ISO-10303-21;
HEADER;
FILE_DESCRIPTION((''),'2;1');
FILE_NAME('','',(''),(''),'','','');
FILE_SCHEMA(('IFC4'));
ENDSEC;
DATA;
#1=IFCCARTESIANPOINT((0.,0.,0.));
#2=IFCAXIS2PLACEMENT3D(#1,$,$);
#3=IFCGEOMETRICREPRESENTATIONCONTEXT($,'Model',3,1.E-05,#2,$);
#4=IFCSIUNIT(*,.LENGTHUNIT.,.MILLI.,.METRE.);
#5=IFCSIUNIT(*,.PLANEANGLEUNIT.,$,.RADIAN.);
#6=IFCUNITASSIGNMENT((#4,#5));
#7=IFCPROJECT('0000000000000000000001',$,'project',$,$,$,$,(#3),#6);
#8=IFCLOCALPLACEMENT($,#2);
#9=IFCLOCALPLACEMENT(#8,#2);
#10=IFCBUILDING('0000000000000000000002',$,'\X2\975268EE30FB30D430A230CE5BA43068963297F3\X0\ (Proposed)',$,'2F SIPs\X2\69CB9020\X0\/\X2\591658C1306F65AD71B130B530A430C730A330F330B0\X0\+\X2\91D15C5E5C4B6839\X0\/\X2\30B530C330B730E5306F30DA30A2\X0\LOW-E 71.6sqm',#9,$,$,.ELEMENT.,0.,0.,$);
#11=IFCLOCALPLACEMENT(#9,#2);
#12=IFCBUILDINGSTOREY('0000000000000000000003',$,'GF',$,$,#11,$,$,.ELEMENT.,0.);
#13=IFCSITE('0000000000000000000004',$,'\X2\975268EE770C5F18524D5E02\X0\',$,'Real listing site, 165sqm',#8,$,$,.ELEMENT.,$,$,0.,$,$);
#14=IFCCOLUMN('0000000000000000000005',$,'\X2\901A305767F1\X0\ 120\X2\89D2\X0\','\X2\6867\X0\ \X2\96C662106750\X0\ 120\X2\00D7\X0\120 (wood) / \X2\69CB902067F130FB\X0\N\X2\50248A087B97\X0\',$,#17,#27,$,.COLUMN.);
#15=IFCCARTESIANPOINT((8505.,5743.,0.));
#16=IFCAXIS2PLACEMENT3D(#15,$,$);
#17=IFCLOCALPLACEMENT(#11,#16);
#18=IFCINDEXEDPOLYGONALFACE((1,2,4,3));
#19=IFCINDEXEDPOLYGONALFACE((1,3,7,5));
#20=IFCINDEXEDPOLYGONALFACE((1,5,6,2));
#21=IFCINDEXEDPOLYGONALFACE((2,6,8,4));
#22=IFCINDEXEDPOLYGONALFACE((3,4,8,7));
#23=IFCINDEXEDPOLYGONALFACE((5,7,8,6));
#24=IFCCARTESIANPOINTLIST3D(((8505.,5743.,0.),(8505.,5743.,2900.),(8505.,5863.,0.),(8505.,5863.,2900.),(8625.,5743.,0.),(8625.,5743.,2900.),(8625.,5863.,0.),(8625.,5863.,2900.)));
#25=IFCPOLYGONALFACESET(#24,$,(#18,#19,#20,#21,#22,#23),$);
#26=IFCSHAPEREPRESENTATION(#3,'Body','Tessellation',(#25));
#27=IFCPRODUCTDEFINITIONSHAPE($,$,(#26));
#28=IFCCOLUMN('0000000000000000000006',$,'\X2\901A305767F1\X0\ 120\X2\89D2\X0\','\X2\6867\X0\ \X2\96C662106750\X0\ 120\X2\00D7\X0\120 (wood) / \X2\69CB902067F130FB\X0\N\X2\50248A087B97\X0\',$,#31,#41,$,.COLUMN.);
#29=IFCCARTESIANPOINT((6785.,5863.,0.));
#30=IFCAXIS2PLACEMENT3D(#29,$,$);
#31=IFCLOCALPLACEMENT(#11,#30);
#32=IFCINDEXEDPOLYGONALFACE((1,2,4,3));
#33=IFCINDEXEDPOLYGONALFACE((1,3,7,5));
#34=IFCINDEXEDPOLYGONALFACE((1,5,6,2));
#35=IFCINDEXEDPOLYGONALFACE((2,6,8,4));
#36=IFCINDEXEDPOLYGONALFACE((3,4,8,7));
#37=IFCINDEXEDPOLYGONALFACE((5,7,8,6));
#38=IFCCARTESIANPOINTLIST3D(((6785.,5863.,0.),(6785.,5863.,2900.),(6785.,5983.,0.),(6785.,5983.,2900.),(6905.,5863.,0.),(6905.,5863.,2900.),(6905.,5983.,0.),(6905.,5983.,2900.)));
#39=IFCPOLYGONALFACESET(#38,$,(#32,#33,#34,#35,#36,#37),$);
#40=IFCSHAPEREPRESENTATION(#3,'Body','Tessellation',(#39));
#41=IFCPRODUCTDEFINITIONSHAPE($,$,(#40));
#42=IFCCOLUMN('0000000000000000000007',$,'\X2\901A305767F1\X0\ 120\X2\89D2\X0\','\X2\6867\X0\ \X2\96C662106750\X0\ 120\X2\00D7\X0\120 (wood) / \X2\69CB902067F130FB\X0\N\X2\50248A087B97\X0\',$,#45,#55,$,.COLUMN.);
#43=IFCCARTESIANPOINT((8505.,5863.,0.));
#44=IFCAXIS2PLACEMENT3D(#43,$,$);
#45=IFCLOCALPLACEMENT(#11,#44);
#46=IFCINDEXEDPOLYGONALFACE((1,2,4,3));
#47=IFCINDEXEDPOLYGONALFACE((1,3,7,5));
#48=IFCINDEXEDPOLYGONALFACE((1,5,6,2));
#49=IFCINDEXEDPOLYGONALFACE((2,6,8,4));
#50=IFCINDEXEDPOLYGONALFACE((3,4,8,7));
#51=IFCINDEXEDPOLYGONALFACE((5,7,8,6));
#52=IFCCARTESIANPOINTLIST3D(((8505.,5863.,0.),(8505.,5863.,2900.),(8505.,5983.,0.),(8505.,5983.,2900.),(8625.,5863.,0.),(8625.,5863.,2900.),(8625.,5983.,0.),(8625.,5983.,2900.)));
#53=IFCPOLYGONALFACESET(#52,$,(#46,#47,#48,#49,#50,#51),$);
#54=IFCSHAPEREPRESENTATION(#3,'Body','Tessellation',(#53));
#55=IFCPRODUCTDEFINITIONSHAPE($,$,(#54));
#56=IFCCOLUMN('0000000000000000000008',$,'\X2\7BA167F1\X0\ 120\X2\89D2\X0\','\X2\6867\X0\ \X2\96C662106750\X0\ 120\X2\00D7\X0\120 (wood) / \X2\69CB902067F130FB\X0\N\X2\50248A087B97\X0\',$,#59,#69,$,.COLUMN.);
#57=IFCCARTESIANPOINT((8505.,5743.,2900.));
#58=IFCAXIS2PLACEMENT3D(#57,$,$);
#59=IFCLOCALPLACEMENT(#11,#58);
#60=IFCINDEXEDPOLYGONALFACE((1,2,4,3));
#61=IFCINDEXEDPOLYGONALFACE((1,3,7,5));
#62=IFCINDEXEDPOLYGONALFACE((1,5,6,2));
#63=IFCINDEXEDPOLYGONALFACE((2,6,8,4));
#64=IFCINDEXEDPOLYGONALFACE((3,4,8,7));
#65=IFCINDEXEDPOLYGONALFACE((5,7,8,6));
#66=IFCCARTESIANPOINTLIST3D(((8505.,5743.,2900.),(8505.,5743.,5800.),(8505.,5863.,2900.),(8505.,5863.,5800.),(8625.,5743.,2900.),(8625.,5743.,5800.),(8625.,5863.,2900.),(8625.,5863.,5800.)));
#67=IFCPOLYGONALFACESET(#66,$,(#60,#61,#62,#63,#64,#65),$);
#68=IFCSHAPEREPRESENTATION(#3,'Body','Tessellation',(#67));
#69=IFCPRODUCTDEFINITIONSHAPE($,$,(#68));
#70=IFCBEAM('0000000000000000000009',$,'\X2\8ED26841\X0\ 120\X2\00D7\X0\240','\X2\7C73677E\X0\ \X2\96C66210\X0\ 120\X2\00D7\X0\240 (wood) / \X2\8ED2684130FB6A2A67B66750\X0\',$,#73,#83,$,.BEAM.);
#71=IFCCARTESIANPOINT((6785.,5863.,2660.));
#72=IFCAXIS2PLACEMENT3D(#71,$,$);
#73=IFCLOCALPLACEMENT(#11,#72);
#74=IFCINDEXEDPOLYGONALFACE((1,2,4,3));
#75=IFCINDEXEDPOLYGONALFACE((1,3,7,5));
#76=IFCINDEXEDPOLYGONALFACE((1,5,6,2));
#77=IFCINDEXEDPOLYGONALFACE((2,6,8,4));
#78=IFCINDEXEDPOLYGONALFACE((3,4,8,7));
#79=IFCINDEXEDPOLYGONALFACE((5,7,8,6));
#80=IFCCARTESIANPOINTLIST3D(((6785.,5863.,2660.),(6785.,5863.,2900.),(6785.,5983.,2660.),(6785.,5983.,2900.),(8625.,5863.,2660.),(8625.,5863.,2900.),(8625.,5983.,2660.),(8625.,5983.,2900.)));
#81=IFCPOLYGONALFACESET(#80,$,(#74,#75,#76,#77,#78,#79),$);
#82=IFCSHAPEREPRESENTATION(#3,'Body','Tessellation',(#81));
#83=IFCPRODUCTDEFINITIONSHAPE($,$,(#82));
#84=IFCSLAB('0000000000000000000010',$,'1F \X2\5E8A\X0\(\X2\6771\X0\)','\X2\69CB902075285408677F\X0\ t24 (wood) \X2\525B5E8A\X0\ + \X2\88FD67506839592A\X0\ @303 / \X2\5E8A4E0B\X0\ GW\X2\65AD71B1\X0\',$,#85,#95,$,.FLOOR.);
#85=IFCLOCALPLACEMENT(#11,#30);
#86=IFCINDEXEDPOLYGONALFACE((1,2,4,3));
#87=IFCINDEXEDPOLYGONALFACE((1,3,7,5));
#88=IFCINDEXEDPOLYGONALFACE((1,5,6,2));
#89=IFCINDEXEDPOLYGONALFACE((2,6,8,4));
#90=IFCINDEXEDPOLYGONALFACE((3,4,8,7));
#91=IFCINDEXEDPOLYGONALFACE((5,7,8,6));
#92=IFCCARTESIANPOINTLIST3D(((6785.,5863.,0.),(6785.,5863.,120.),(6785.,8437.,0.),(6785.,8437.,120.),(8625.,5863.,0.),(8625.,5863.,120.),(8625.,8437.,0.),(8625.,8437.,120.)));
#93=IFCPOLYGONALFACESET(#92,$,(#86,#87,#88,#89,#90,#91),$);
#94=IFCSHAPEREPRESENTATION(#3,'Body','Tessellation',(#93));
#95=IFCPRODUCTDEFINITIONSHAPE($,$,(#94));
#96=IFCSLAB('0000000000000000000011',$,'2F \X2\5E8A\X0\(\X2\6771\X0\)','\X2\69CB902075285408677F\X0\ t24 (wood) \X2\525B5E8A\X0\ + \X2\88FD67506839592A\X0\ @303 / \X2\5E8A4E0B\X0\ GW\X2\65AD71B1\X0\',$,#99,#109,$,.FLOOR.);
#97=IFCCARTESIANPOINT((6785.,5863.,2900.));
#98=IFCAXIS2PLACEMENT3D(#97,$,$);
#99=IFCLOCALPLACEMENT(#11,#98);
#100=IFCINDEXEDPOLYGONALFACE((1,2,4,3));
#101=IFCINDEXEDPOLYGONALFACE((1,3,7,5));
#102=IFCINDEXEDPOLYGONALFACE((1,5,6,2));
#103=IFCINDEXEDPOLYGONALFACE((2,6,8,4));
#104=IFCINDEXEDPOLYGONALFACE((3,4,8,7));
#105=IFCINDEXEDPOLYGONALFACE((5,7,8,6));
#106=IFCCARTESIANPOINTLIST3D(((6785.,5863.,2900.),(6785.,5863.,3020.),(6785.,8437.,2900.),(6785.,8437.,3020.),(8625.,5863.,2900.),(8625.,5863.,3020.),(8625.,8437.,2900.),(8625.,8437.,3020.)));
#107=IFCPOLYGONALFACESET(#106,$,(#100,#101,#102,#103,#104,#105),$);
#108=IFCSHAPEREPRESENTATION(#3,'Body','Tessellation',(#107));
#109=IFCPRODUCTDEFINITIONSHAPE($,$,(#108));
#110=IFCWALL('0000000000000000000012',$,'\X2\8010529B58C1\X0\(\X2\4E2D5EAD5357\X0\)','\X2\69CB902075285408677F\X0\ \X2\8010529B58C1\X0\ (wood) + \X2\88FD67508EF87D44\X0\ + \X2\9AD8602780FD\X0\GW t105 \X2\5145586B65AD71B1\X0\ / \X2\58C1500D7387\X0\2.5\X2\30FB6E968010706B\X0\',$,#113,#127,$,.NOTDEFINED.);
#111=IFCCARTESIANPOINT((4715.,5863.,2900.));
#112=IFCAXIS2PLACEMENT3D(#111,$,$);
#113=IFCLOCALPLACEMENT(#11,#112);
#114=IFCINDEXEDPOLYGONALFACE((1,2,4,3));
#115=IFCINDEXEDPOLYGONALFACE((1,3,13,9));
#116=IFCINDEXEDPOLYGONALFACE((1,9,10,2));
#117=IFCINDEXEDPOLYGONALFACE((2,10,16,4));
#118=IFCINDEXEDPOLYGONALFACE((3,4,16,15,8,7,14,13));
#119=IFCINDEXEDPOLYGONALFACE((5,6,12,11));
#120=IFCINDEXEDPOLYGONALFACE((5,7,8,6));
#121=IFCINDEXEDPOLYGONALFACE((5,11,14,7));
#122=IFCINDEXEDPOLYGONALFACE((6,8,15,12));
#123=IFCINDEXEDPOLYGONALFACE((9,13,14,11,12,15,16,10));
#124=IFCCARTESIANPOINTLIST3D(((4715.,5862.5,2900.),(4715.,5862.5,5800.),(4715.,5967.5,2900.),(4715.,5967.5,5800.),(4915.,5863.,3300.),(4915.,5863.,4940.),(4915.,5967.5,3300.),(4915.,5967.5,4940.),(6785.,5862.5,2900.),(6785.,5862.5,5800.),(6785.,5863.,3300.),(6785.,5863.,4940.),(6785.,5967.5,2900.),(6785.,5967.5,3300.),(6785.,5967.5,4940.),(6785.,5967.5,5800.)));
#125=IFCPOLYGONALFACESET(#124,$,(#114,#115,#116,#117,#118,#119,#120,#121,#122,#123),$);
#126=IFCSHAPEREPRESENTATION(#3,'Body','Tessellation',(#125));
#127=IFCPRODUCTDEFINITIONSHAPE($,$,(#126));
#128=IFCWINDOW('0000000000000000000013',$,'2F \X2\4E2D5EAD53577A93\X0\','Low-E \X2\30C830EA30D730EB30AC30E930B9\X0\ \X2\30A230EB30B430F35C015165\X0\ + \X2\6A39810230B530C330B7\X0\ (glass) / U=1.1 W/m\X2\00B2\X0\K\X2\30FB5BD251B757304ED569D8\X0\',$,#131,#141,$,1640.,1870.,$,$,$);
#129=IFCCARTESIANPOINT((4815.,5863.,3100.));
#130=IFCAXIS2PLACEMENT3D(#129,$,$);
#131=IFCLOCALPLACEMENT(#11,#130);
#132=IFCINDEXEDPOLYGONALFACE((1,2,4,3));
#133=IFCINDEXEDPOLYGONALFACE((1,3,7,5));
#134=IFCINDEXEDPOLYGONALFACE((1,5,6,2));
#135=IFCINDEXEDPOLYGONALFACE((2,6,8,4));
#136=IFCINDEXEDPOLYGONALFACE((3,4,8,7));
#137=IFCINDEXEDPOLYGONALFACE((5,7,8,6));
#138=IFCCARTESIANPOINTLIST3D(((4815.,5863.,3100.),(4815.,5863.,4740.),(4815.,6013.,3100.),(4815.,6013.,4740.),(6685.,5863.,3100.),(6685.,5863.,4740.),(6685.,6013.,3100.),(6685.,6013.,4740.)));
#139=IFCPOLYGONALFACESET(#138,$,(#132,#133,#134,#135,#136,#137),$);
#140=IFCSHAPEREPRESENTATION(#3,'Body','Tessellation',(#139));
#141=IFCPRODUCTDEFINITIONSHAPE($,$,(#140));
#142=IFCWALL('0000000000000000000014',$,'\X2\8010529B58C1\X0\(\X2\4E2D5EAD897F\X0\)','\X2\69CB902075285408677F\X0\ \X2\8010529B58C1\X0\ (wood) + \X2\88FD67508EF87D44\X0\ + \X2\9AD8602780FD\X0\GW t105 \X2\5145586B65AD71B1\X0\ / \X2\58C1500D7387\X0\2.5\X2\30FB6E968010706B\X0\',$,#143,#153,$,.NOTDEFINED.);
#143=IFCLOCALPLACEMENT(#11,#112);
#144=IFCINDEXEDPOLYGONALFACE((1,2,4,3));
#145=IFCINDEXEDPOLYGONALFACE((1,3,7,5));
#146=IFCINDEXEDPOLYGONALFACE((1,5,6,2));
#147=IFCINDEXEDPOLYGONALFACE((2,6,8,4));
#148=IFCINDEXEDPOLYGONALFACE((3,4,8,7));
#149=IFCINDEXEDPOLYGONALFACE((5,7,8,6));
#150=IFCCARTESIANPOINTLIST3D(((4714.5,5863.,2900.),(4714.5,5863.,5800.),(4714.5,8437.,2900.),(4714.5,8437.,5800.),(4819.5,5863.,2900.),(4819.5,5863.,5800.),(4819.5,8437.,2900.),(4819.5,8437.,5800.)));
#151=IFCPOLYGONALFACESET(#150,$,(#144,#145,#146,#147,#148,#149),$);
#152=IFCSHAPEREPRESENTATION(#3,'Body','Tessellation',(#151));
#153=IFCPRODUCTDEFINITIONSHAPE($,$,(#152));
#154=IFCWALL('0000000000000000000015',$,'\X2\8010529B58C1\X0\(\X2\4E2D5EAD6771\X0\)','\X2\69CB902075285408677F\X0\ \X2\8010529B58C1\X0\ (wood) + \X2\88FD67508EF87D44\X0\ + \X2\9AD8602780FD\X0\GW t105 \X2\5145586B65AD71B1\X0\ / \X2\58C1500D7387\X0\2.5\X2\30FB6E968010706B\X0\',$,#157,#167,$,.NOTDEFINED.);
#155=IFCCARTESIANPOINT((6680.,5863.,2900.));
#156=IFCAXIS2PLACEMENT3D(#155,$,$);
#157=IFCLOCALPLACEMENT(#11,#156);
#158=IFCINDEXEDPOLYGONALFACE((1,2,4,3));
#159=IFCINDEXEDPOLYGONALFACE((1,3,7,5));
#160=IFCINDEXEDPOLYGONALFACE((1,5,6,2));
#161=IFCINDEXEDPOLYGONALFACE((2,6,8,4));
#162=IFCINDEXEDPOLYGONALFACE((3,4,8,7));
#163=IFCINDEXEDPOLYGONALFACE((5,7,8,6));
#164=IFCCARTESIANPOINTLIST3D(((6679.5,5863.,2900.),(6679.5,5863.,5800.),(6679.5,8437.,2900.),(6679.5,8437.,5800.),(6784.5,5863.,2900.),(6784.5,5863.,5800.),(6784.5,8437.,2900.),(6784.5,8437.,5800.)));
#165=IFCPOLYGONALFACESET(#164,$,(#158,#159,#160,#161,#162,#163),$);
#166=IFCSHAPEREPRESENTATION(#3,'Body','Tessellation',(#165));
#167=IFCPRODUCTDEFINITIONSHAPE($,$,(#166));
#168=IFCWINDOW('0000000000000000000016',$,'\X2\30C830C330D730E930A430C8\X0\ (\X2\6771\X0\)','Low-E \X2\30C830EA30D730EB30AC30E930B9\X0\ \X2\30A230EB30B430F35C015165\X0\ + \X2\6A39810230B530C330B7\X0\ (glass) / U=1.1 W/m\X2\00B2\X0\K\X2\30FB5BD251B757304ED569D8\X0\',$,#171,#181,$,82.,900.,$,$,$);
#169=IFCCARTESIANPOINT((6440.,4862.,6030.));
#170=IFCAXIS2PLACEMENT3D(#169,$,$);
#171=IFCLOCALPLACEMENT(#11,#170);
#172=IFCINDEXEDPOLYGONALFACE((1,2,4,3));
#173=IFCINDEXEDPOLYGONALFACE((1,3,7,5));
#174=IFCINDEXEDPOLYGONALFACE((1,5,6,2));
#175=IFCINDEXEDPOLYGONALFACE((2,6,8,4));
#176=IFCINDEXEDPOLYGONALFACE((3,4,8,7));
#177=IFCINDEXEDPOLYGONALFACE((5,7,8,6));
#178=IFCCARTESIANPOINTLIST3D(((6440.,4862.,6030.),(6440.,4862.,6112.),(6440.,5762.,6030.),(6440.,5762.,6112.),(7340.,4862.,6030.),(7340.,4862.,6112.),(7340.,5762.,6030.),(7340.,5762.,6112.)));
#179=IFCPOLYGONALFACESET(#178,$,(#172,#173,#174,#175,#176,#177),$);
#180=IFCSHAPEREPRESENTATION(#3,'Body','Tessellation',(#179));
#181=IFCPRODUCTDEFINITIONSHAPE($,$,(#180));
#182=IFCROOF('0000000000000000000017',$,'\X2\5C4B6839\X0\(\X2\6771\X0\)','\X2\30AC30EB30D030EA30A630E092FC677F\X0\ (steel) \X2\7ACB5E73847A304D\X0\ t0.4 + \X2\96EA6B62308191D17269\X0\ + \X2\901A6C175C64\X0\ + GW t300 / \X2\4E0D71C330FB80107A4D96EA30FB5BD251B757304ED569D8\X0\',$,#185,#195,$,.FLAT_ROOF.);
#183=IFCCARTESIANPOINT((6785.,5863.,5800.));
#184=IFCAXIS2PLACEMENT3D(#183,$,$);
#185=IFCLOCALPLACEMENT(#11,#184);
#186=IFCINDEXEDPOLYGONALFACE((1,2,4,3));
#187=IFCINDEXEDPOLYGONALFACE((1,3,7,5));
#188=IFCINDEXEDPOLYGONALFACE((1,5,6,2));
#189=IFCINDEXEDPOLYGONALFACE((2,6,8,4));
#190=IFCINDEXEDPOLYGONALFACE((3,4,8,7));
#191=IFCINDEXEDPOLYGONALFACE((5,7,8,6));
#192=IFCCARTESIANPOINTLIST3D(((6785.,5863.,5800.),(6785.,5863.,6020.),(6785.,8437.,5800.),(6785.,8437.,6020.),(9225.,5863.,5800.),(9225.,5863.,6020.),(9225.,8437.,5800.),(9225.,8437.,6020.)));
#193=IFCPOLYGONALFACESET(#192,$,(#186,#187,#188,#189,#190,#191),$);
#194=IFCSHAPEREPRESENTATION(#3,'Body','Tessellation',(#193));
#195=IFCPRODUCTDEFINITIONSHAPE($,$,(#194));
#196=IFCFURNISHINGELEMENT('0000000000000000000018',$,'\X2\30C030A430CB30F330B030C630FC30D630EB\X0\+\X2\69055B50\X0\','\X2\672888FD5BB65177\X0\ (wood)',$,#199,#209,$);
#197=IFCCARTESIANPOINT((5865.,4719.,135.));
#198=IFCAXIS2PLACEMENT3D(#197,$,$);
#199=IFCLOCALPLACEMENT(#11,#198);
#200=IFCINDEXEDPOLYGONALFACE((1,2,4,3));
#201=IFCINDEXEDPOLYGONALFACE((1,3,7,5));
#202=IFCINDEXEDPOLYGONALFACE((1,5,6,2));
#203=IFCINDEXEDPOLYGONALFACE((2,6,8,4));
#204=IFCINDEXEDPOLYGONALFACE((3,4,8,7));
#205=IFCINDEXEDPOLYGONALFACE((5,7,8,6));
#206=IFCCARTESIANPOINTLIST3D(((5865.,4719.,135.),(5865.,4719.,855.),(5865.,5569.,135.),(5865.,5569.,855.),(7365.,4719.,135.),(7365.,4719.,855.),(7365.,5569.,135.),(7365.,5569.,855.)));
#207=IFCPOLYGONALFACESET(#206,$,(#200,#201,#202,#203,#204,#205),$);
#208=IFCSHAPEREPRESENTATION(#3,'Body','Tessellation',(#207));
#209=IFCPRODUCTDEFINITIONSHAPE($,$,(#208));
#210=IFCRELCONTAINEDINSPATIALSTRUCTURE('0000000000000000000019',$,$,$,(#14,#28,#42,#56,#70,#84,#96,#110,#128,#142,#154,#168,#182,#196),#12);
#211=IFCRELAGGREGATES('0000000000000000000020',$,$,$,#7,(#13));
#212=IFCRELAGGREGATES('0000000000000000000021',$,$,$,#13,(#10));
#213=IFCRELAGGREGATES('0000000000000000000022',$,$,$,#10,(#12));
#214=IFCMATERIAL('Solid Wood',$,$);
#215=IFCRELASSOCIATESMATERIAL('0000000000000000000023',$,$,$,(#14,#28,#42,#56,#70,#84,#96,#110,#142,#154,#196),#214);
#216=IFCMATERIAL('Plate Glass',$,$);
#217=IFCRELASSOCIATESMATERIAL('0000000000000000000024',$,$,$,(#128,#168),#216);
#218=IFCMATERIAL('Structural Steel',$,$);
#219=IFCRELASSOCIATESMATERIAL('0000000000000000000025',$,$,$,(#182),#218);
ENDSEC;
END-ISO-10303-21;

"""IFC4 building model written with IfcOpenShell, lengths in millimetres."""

from ifc_helpers import new_model, si_unit, frame, frame_2d, origin, place, context, project, spatial, rectangle, extrude, material, element, fill, save


model = new_model("IFC4")

# Units and contexts
model_context = context("Model", 3, precision=1e-05, world=origin())
ifc_project = project(units=[si_unit("LENGTHUNIT", "METRE", prefix="MILLI"), si_unit("PLANEANGLEUNIT", "RADIAN")], contexts=[model_context])

# Site, building, storey
site_placement = place(None, origin())
site = spatial("IfcSite", under=ifc_project, at=site_placement, Name="青森県弘前市", ObjectType="Real listing site, 165sqm", CompositionType="ELEMENT", RefElevation=0.0)
building_placement = place(site_placement, origin())
building = spatial("IfcBuilding", under=site, at=building_placement, Name="青森・ピアノ室と防音 (Proposed)", ObjectType="2F SIPs構造/外壁は断熱サイディング+金属屋根/サッシュはペアLOW-E 71.6sqm", CompositionType="ELEMENT", ElevationOfRefHeight=0.0, ElevationOfTerrain=0.0)
storey_placement = place(building_placement, origin())
storey = spatial("IfcBuildingStorey", under=building, at=storey_placement, Name="GF", CompositionType="ELEMENT", Elevation=0.0)

# Columns
ifc_material_1 = material(Name="Solid Wood")
column_1_placement = place(storey_placement, frame((8505.0, 5743.0, 0.0)))
element("IfcColumn", 1, at=column_1_placement, inside=storey, material=ifc_material_1, Name="通し柱 120角", Description="桧 集成材 120×120 (wood) / 構造柱・N値計算", PredefinedType="COLUMN", context=model_context, shape_type="SweptSolid", body=[
    extrude(rectangle(XDim=120.0, YDim=120.0, at=frame_2d((60.0, 60.0))), frame((8505.0, 5743.0, 0.0)), (0.0, 0.0, 1.0), 2900.0),
])
column_2_placement = place(storey_placement, frame((6785.0, 5863.0, 0.0)))
element("IfcColumn", 2, at=column_2_placement, inside=storey, material=ifc_material_1, Name="通し柱 120角", Description="桧 集成材 120×120 (wood) / 構造柱・N値計算", PredefinedType="COLUMN", context=model_context, shape_type="SweptSolid", body=[
    extrude(rectangle(XDim=120.0, YDim=120.0, at=frame_2d((60.0, 60.0))), frame((6785.0, 5863.0, 0.0)), (0.0, 0.0, 1.0), 2900.0),
])
column_3_placement = place(storey_placement, frame((8505.0, 5863.0, 0.0)))
element("IfcColumn", 3, at=column_3_placement, inside=storey, material=ifc_material_1, Name="通し柱 120角", Description="桧 集成材 120×120 (wood) / 構造柱・N値計算", PredefinedType="COLUMN", context=model_context, shape_type="SweptSolid", body=[
    extrude(rectangle(XDim=120.0, YDim=120.0, at=frame_2d((60.0, 60.0))), frame((8505.0, 5863.0, 0.0)), (0.0, 0.0, 1.0), 2900.0),
])
column_4_placement = place(storey_placement, frame((8505.0, 5743.0, 2900.0)))
element("IfcColumn", 4, at=column_4_placement, inside=storey, material=ifc_material_1, Name="管柱 120角", Description="桧 集成材 120×120 (wood) / 構造柱・N値計算", PredefinedType="COLUMN", context=model_context, shape_type="SweptSolid", body=[
    extrude(rectangle(XDim=120.0, YDim=120.0, at=frame_2d((60.0, 60.0))), frame((8505.0, 5743.0, 2900.0)), (0.0, 0.0, 1.0), 2900.0),
])

# Beam
beam_1_placement = place(storey_placement, frame((6785.0, 5863.0, 2660.0)))
element("IfcBeam", 5, at=beam_1_placement, inside=storey, material=ifc_material_1, Name="軒桁 120×240", Description="米松 集成 120×240 (wood) / 軒桁・横架材", PredefinedType="BEAM", context=model_context, shape_type="SweptSolid", body=[
    extrude(rectangle(XDim=1840.0, YDim=120.0, at=frame_2d((920.0, 60.0))), frame((6785.0, 5863.0, 2660.0)), (0.0, 0.0, 1.0), 240.0),
])

# Slabs
slab_1_placement = place(storey_placement, frame((6785.0, 5863.0, 0.0)))
element("IfcSlab", 6, at=slab_1_placement, inside=storey, material=ifc_material_1, Name="1F 床(東)", Description="構造用合板 t24 (wood) 剛床 + 製材根太 @303 / 床下 GW断熱", PredefinedType="FLOOR", context=model_context, shape_type="SweptSolid", body=[
    extrude(rectangle(XDim=1840.0, YDim=2574.0, at=frame_2d((920.0, 1287.0))), frame((6785.0, 5863.0, 0.0)), (0.0, 0.0, 1.0), 120.0),
])
slab_2_placement = place(storey_placement, frame((6785.0, 5863.0, 2900.0)))
element("IfcSlab", 7, at=slab_2_placement, inside=storey, material=ifc_material_1, Name="2F 床(東)", Description="構造用合板 t24 (wood) 剛床 + 製材根太 @303 / 床下 GW断熱", PredefinedType="FLOOR", context=model_context, shape_type="SweptSolid", body=[
    extrude(rectangle(XDim=1840.0, YDim=2574.0, at=frame_2d((920.0, 1287.0))), frame((6785.0, 5863.0, 2900.0)), (0.0, 0.0, 1.0), 120.0),
])

# Wall, opening, window
wall_1_placement = place(storey_placement, frame((4715.0, 5863.0, 2900.0)))
wall_1 = element("IfcWall", 8, at=wall_1_placement, inside=storey, material=ifc_material_1, Name="耐力壁(中庭南)", Description="構造用合板 耐力壁 (wood) + 製材軸組 + 高性能GW t105 充填断熱 / 壁倍率2.5・準耐火", PredefinedType="NOTDEFINED", context=model_context, shape_type="SweptSolid", body=[
    extrude(rectangle(XDim=2070.0, YDim=105.0, at=frame_2d((1035.0, 52.0))), frame((4715.0, 5863.0, 2900.0)), (0.0, 0.0, 1.0), 2900.0),
])
opening_placement = place(storey_placement, frame((4815.0, 5863.0, 3100.0)))
opening = element("IfcOpeningElement", 9, at=opening_placement, cuts=wall_1, PredefinedType="NOTDEFINED", context=model_context, shape_type="SweptSolid", body=[
    extrude(rectangle(XDim=1870.0, YDim=150.0, at=frame_2d((935.0, 75.0))), frame((4815.0, 5863.0, 3100.0)), (0.0, 0.0, 1.0), 1640.0),
])
ifc_material_2 = material(Name="Plate Glass")
window_1_placement = place(storey_placement, frame((4815.0, 5863.0, 3100.0)))
window_1 = element("IfcWindow", 10, at=window_1_placement, inside=storey, material=ifc_material_2, Name="2F 中庭南窓", Description="Low-E トリプルガラス アルゴン封入 + 樹脂サッシ (glass) / U=1.1 W/m²K・寒冷地仕様", OverallHeight=1640.0, OverallWidth=1870.0, context=model_context, shape_type="SweptSolid", body=[
    extrude(rectangle(XDim=1870.0, YDim=150.0, at=frame_2d((935.0, 75.0))), frame((4815.0, 5863.0, 3100.0)), (0.0, 0.0, 1.0), 1640.0),
])
fill(opening, window_1)

# Walls
wall_2_placement = place(storey_placement, frame((4715.0, 5863.0, 2900.0)))
element("IfcWall", 11, at=wall_2_placement, inside=storey, material=ifc_material_1, Name="耐力壁(中庭西)", Description="構造用合板 耐力壁 (wood) + 製材軸組 + 高性能GW t105 充填断熱 / 壁倍率2.5・準耐火", PredefinedType="NOTDEFINED", context=model_context, shape_type="SweptSolid", body=[
    extrude(rectangle(XDim=105.0, YDim=2574.0, at=frame_2d((52.0, 1287.0))), frame((4715.0, 5863.0, 2900.0)), (0.0, 0.0, 1.0), 2900.0),
])
wall_3_placement = place(storey_placement, frame((6680.0, 5863.0, 2900.0)))
element("IfcWall", 12, at=wall_3_placement, inside=storey, material=ifc_material_1, Name="耐力壁(中庭東)", Description="構造用合板 耐力壁 (wood) + 製材軸組 + 高性能GW t105 充填断熱 / 壁倍率2.5・準耐火", PredefinedType="NOTDEFINED", context=model_context, shape_type="SweptSolid", body=[
    extrude(rectangle(XDim=105.0, YDim=2574.0, at=frame_2d((52.0, 1287.0))), frame((6680.0, 5863.0, 2900.0)), (0.0, 0.0, 1.0), 2900.0),
])

# Window
window_2_placement = place(storey_placement, frame((6440.0, 4862.0, 6030.0)))
element("IfcWindow", 13, at=window_2_placement, inside=storey, material=ifc_material_2, Name="トップライト (東)", Description="Low-E トリプルガラス アルゴン封入 + 樹脂サッシ (glass) / U=1.1 W/m²K・寒冷地仕様", OverallHeight=82.0, OverallWidth=900.0, context=model_context, shape_type="SweptSolid", body=[
    extrude(rectangle(XDim=900.0, YDim=900.0, at=frame_2d((450.0, 450.0))), frame((6440.0, 4862.0, 6030.0)), (0.0, 0.0, 1.0), 82.0),
])

# Roof
ifc_material_3 = material(Name="Structural Steel")
for number, where, name in (
    (14, (6785.0, 5863.0, 5800.0), "屋根(東)"),
):
    element("IfcRoof", number, at=place(storey_placement, frame(where)), inside=storey, material=ifc_material_3, Name=name, Description="ガルバリウム鋼板 (steel) 立平葺き t0.4 + 雪止め金物 + 通気層 + GW t300 / 不燃・耐積雪・寒冷地仕様", PredefinedType="FLAT_ROOF", context=model_context, shape_type="SweptSolid", body=[
        extrude(rectangle(XDim=2440.0, YDim=2574.0, at=frame_2d((1220.0, 1287.0))), frame((6785.0, 5863.0, 5800.0)), (0.0, 0.0, 1.0), 220.0),
    ])

# Furnishing element
furnishing_1_placement = place(storey_placement, frame((5865.0, 4719.0, 135.0)))
element("IfcFurnishingElement", 15, at=furnishing_1_placement, inside=storey, material=ifc_material_1, Name="ダイニングテーブル+椅子", Description="木製家具 (wood)", context=model_context, shape_type="SweptSolid", body=[
    extrude(rectangle(XDim=1500.0, YDim=850.0, at=frame_2d((750.0, 425.0))), frame((5865.0, 4719.0, 135.0)), (0.0, 0.0, 1.0), 720.0),
])

save(model, "model.ifc")
